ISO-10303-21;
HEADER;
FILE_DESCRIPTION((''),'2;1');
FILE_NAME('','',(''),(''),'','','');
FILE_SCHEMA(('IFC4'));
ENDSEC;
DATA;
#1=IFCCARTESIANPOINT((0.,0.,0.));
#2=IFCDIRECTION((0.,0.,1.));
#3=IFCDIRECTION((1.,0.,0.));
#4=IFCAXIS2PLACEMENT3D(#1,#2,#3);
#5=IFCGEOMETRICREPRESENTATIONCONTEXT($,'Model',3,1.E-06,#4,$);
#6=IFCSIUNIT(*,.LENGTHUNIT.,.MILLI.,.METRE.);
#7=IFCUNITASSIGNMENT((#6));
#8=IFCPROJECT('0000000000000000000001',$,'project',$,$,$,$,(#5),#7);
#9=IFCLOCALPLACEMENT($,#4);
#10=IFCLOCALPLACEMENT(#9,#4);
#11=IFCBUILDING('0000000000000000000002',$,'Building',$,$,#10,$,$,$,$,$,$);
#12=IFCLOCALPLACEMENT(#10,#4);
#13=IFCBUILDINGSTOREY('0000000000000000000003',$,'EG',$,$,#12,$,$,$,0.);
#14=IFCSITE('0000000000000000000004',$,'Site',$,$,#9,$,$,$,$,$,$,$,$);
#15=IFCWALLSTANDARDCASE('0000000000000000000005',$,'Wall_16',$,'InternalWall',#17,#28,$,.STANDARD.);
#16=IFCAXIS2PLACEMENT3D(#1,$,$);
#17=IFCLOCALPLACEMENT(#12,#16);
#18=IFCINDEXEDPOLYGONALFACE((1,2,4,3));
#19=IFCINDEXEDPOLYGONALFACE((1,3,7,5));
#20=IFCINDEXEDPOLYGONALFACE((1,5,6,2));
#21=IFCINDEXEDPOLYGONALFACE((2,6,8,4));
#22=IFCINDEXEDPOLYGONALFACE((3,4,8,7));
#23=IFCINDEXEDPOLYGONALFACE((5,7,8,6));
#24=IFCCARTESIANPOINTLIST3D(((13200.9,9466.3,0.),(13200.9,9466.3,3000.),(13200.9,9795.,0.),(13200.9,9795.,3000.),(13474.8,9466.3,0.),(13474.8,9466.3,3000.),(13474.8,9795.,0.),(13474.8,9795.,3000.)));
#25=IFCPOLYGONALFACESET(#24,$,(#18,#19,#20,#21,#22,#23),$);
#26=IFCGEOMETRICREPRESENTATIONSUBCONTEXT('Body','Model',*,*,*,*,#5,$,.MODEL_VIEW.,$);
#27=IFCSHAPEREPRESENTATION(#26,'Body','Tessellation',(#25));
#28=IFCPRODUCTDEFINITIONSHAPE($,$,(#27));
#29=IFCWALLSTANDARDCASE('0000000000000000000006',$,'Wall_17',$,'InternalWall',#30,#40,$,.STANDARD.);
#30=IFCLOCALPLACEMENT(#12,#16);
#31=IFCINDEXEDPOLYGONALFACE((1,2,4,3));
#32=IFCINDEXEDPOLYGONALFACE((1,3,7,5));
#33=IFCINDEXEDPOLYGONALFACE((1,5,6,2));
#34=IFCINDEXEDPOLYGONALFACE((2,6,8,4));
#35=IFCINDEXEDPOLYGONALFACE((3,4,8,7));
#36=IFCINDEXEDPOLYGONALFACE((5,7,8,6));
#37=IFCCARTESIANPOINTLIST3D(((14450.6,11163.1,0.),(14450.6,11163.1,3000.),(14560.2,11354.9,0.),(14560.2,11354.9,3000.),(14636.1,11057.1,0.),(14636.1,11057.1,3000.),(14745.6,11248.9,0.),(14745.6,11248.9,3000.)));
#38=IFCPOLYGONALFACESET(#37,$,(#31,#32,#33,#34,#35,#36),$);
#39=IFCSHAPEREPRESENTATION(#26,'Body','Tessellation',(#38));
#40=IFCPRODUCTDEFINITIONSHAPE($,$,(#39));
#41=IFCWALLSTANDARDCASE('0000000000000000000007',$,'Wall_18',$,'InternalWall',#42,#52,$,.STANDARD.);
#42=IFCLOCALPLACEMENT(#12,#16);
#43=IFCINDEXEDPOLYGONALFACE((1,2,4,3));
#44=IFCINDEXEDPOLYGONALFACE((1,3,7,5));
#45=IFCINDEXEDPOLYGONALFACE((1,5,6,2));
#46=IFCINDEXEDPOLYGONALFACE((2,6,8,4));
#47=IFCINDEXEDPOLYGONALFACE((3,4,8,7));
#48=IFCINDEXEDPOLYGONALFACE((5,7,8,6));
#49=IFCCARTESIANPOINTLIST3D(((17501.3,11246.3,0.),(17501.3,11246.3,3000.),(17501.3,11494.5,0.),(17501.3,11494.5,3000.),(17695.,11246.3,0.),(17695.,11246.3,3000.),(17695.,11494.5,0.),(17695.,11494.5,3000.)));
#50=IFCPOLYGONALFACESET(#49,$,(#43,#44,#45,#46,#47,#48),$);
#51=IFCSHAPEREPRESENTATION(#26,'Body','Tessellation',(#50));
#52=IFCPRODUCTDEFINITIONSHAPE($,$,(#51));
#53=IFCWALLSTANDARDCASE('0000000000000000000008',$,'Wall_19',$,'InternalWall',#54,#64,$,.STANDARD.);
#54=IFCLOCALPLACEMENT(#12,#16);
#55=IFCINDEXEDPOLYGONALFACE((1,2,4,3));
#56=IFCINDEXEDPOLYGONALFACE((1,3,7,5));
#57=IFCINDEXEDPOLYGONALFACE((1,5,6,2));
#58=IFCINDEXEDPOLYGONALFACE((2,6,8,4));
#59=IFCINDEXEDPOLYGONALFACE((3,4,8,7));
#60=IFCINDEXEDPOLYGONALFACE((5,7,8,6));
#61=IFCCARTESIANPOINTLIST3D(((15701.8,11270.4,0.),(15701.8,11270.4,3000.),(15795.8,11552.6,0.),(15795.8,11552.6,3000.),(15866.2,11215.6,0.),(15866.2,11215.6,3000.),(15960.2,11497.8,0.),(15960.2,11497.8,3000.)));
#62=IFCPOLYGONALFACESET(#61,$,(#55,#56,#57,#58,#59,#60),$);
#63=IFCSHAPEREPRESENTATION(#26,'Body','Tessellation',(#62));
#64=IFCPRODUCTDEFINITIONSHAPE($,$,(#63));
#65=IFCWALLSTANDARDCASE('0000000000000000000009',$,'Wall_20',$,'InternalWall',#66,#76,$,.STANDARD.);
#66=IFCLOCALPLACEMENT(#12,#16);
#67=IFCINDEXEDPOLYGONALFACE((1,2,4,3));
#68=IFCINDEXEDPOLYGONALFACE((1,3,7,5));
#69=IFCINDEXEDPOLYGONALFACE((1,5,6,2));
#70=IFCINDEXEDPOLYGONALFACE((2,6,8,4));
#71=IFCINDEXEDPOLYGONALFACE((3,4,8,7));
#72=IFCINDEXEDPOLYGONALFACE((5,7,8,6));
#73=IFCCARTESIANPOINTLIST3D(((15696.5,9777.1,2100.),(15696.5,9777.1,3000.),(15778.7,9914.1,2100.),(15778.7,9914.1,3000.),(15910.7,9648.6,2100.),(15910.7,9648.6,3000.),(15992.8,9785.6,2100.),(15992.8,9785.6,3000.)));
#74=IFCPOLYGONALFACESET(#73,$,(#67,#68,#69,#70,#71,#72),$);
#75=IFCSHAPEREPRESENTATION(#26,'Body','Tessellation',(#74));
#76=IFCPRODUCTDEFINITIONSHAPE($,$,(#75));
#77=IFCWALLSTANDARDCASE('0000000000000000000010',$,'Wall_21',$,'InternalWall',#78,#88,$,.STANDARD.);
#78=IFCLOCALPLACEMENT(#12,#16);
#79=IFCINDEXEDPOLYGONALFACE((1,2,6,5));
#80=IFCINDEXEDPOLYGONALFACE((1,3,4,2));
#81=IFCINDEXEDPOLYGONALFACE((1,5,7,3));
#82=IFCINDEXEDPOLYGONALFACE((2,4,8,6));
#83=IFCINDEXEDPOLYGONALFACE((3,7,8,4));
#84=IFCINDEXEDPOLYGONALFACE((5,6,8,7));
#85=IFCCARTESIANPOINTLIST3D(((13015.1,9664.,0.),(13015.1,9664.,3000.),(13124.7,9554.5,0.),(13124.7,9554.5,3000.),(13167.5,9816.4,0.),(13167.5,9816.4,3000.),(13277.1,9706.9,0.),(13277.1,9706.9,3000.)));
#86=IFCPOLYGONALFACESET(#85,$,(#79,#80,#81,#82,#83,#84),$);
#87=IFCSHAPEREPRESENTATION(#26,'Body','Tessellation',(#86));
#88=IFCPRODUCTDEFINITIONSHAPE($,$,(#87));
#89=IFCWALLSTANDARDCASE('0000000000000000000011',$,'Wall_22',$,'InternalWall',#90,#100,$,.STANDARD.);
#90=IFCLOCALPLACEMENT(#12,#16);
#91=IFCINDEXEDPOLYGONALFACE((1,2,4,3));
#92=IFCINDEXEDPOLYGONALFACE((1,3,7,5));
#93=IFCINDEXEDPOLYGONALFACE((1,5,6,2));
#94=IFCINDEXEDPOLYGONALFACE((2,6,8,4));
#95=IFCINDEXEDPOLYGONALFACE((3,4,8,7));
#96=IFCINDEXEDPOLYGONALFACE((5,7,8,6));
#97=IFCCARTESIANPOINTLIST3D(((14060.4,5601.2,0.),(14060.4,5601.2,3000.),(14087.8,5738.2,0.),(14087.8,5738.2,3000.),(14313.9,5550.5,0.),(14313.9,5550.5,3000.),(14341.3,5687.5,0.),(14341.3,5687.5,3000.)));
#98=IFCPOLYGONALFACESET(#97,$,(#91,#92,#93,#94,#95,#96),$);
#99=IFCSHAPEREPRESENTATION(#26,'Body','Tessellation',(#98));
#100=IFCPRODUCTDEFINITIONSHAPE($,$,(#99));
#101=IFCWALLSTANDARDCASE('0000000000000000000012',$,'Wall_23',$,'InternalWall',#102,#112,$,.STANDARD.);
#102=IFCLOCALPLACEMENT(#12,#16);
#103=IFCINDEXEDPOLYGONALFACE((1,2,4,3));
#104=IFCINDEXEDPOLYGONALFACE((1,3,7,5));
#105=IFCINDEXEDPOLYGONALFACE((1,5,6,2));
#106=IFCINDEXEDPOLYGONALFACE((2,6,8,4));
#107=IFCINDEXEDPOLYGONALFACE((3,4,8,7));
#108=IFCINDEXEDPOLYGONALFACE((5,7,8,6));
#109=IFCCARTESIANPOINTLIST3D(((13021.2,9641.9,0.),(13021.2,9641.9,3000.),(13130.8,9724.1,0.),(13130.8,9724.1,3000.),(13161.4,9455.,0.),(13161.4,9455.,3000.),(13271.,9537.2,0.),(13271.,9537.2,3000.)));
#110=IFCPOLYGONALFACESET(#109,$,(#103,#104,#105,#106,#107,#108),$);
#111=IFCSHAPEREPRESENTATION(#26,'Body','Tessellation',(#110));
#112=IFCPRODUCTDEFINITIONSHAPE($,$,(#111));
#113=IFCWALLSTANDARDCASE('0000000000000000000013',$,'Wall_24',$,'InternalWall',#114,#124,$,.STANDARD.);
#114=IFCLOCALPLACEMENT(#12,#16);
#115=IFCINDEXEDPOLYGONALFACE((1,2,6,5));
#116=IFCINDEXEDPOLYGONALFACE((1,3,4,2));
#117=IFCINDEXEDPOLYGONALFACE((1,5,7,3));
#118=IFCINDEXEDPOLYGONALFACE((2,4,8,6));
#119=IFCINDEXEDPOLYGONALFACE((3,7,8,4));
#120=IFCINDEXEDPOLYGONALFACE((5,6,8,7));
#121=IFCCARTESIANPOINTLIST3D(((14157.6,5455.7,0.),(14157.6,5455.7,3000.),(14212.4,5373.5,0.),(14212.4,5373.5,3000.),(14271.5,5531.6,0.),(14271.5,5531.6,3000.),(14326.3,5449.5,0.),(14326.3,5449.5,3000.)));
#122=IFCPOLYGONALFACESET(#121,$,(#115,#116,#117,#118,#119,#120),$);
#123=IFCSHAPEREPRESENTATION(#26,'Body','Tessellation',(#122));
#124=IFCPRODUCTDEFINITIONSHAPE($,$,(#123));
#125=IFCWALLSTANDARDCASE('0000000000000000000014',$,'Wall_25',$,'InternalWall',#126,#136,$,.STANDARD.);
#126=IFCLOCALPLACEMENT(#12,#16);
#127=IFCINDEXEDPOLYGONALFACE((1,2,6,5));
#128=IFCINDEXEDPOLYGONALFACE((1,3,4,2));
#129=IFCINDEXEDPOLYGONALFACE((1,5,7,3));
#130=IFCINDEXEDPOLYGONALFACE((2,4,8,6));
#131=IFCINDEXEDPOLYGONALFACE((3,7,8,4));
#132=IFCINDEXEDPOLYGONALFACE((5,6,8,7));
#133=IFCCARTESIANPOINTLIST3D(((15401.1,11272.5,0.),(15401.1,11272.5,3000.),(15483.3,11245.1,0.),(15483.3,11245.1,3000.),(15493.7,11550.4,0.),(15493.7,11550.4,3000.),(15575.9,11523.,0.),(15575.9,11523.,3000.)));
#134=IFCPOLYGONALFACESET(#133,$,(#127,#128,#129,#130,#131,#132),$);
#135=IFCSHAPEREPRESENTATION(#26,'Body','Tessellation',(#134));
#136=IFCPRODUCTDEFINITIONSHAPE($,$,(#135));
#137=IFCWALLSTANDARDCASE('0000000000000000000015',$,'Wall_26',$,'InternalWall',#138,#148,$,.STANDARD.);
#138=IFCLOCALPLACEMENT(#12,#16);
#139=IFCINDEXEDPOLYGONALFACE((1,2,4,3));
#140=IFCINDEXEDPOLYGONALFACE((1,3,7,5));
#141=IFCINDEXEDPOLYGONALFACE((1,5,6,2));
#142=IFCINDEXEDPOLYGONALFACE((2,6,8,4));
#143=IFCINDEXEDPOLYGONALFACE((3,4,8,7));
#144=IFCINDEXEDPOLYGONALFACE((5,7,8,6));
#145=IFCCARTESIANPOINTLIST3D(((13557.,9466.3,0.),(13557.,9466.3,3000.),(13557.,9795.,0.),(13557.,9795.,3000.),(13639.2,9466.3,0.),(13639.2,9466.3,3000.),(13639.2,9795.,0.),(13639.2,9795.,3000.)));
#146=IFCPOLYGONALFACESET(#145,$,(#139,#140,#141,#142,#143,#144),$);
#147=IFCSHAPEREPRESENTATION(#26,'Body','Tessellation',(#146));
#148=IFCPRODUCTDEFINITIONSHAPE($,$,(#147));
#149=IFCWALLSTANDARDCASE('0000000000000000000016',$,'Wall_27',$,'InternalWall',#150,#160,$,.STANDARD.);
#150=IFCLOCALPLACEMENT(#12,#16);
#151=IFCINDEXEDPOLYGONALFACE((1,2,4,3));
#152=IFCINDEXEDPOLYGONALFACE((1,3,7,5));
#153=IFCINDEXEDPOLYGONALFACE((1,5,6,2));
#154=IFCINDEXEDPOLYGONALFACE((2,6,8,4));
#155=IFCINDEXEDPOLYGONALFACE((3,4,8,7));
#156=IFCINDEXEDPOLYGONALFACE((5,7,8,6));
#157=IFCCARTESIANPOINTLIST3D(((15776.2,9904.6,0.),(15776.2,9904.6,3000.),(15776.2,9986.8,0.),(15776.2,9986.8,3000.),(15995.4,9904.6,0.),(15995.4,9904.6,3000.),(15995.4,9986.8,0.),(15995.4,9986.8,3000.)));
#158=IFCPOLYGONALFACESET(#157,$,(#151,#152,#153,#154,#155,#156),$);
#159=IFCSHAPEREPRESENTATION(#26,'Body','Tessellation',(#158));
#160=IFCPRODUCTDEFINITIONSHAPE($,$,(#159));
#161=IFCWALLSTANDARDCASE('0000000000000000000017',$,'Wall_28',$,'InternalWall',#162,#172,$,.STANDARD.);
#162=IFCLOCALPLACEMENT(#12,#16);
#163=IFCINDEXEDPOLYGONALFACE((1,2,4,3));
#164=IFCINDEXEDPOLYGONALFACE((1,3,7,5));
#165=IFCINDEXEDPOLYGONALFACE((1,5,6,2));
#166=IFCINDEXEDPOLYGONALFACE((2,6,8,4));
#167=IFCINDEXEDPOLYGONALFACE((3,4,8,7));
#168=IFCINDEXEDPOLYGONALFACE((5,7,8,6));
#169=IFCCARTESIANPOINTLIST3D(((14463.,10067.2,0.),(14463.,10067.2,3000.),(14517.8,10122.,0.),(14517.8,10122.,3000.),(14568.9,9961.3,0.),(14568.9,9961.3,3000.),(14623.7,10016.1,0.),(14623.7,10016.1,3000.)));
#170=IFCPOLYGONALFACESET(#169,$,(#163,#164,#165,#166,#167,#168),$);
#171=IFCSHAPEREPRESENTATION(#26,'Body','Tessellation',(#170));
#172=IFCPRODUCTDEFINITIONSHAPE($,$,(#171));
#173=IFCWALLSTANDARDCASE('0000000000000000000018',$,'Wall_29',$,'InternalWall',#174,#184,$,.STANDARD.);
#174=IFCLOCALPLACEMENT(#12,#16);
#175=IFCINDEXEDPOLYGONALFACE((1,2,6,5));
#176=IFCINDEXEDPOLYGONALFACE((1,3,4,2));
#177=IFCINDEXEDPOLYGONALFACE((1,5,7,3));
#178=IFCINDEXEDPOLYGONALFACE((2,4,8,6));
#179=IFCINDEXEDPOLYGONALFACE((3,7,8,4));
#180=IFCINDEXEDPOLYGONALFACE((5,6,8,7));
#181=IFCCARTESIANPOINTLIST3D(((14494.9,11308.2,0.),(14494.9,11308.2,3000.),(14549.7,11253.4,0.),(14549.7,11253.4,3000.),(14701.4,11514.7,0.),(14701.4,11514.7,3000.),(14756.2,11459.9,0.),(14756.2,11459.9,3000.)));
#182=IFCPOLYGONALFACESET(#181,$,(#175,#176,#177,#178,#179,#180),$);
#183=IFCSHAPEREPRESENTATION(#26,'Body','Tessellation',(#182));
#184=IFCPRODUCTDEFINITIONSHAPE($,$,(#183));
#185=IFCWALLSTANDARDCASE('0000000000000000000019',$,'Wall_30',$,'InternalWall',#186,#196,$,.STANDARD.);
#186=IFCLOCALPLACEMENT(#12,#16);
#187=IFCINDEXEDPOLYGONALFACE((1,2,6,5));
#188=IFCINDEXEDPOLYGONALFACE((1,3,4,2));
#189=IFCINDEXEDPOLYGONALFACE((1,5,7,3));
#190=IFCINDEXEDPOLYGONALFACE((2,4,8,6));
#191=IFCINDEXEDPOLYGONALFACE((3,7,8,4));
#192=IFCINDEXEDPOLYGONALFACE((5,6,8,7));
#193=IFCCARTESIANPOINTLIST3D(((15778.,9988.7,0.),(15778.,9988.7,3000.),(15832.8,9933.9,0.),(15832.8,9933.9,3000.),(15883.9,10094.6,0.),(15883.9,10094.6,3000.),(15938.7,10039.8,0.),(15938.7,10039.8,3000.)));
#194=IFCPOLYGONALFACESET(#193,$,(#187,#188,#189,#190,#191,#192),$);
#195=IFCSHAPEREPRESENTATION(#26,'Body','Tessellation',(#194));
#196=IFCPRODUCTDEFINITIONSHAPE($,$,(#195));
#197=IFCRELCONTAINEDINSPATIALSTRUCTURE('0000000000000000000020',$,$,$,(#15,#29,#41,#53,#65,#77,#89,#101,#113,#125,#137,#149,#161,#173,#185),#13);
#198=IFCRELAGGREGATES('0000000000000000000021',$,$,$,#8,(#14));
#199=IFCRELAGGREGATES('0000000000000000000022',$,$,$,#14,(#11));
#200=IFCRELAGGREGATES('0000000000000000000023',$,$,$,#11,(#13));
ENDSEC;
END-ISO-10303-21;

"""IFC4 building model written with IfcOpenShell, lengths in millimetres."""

from ifc_helpers import new_model, si_unit, frame, origin_with_axes, place, context, subcontext, project, spatial, rectangle, extrude, element, save


model = new_model("IFC4")

# Units and contexts
model_context = context("Model", 3, precision=1e-06, world=origin_with_axes())
body_context = subcontext(model_context, "Body", "Model", "MODEL_VIEW")
ifc_project = project(units=[si_unit("LENGTHUNIT", "METRE", prefix="MILLI")], contexts=[model_context])

# Site, building, storey
site_placement = place(None, origin_with_axes())
site = spatial("IfcSite", under=ifc_project, at=site_placement, Name="Site")
building_placement = place(site_placement, origin_with_axes())
building = spatial("IfcBuilding", under=site, at=building_placement, Name="Building")
storey_placement = place(building_placement, origin_with_axes())
storey = spatial("IfcBuildingStorey", under=building, at=storey_placement, Name="EG", Elevation=0.0)

# Walls
wall_1_placement = place(storey_placement, origin_with_axes())
element("IfcWallStandardCase", 1, at=wall_1_placement, inside=storey, Name="Wall_16", ObjectType="InternalWall", PredefinedType="STANDARD", context=body_context, shape_type="SweptSolid", body=[
    extrude(rectangle(XDim=274.0, YDim=328.8), frame((13337.8, 9630.7, 0.0), z_axis=(0.0, 0.0, 1.0), x_axis=(-1.0, 0.0, 0.0)), (0.0, 0.0, 1.0), 3000.0),
])
wall_2_placement = place(storey_placement, origin_with_axes())
element("IfcWallStandardCase", 2, at=wall_2_placement, inside=storey, Name="Wall_17", ObjectType="InternalWall", PredefinedType="STANDARD", context=body_context, shape_type="SweptSolid", body=[
    extrude(rectangle(XDim=220.9, YDim=213.6), frame((14598.1, 11206.0, 0.0), z_axis=(0.0, 0.0, 1.0), x_axis=(-0.496139, -0.868243, 0.0)), (0.0, 0.0, 1.0), 3000.0),
])
wall_3_placement = place(storey_placement, origin_with_axes())
element("IfcWallStandardCase", 3, at=wall_3_placement, inside=storey, Name="Wall_18", ObjectType="InternalWall", PredefinedType="STANDARD", context=body_context, shape_type="SweptSolid", body=[
    extrude(rectangle(XDim=193.7, YDim=248.2), frame((17598.1, 11370.4, 0.0), z_axis=(0.0, 0.0, 1.0), x_axis=(1.0, 0.0, 0.0)), (0.0, 0.0, 1.0), 3000.0),
])
wall_4_placement = place(storey_placement, origin_with_axes())
element("IfcWallStandardCase", 4, at=wall_4_placement, inside=storey, Name="Wall_19", ObjectType="InternalWall", PredefinedType="STANDARD", context=body_context, shape_type="SweptSolid", body=[
    extrude(rectangle(XDim=173.3, YDim=297.5), frame((15831.0, 11384.1, 0.0), z_axis=(0.0, 0.0, 1.0), x_axis=(0.948683, -0.316228, 0.0)), (0.0, 0.0, 1.0), 3000.0),
])

# Wall, opening
wall_5_placement = place(storey_placement, origin_with_axes())
wall_5 = element("IfcWallStandardCase", 5, at=wall_5_placement, inside=storey, Name="Wall_20", ObjectType="InternalWall", PredefinedType="STANDARD", context=body_context, shape_type="SweptSolid", body=[
    extrude(rectangle(XDim=159.8, YDim=249.7), frame((15844.7, 9781.3, 0.0), z_axis=(0.0, 0.0, 1.0), x_axis=(0.514496, 0.857493, 0.0)), (0.0, 0.0, 1.0), 3000.0),
])
opening_1_placement = place(wall_5_placement, origin_with_axes())
element("IfcOpeningElement", 6, at=opening_1_placement, inside=storey, cuts=wall_5, context=body_context, shape_type="SweptSolid", body=[
    extrude(rectangle(XDim=450.0, YDim=249.7), frame((15844.7, 9781.3, 0.0), z_axis=(0.0, 0.0, 1.0), x_axis=(0.514496, 0.857493, 0.0)), (0.0, 0.0, 1.0), 2100.0),
])

# Walls
wall_6_placement = place(storey_placement, origin_with_axes())
element("IfcWallStandardCase", 7, at=wall_6_placement, inside=storey, Name="Wall_21", ObjectType="InternalWall", PredefinedType="STANDARD", context=body_context, shape_type="SweptSolid", body=[
    extrude(rectangle(XDim=155.0, YDim=215.5), frame((13146.1, 9685.4, 0.0), z_axis=(0.0, 0.0, 1.0), x_axis=(-0.707107, 0.707107, 0.0)), (0.0, 0.0, 1.0), 3000.0),
])
wall_7_placement = place(storey_placement, origin_with_axes())
element("IfcWallStandardCase", 8, at=wall_7_placement, inside=storey, Name="Wall_22", ObjectType="InternalWall", PredefinedType="STANDARD", context=body_context, shape_type="SweptSolid", body=[
    extrude(rectangle(XDim=139.7, YDim=258.5), frame((14200.9, 5644.3, 0.0), z_axis=(0.0, 0.0, 1.0), x_axis=(-0.196116, -0.980581, 0.0)), (0.0, 0.0, 1.0), 3000.0),
])
wall_8_placement = place(storey_placement, origin_with_axes())
element("IfcWallStandardCase", 9, at=wall_8_placement, inside=storey, Name="Wall_23", ObjectType="InternalWall", PredefinedType="STANDARD", context=body_context, shape_type="SweptSolid", body=[
    extrude(rectangle(XDim=137.0, YDim=233.7), frame((13146.1, 9589.6, 0.0), z_axis=(0.0, 0.0, 1.0), x_axis=(-0.8, -0.6, 0.0)), (0.0, 0.0, 1.0), 3000.0),
])
wall_9_placement = place(storey_placement, origin_with_axes())
element("IfcWallStandardCase", 10, at=wall_9_placement, inside=storey, Name="Wall_24", ObjectType="InternalWall", PredefinedType="STANDARD", context=body_context, shape_type="SweptSolid", body=[
    extrude(rectangle(XDim=98.8, YDim=136.9), frame((14242.0, 5452.6, 0.0), z_axis=(0.0, 0.0, 1.0), x_axis=(0.5547, -0.83205, 0.0)), (0.0, 0.0, 1.0), 3000.0),
])
wall_10_placement = place(storey_placement, origin_with_axes())
element("IfcWallStandardCase", 11, at=wall_10_placement, inside=storey, Name="Wall_25", ObjectType="InternalWall", PredefinedType="STANDARD", context=body_context, shape_type="SweptSolid", body=[
    extrude(rectangle(XDim=86.6, YDim=292.9), frame((15488.5, 11397.8, 0.0), z_axis=(0.0, 0.0, 1.0), x_axis=(0.948683, -0.316228, 0.0)), (0.0, 0.0, 1.0), 3000.0),
])
wall_11_placement = place(storey_placement, origin_with_axes())
element("IfcWallStandardCase", 12, at=wall_11_placement, inside=storey, Name="Wall_26", ObjectType="InternalWall", PredefinedType="STANDARD", context=body_context, shape_type="SweptSolid", body=[
    extrude(rectangle(XDim=82.2, YDim=328.8), frame((13598.1, 9630.7, 0.0), z_axis=(0.0, 0.0, 1.0), x_axis=(-1.0, 0.0, 0.0)), (0.0, 0.0, 1.0), 3000.0),
])
wall_12_placement = place(storey_placement, origin_with_axes())
element("IfcWallStandardCase", 13, at=wall_12_placement, inside=storey, Name="Wall_27", ObjectType="InternalWall", PredefinedType="STANDARD", context=body_context, shape_type="SweptSolid", body=[
    extrude(rectangle(XDim=82.2, YDim=219.2), frame((15885.8, 9945.7, 0.0), z_axis=(0.0, 0.0, 1.0), x_axis=(0.0, 1.0, 0.0)), (0.0, 0.0, 1.0), 3000.0),
])
wall_13_placement = place(storey_placement, origin_with_axes())
element("IfcWallStandardCase", 14, at=wall_13_placement, inside=storey, Name="Wall_28", ObjectType="InternalWall", PredefinedType="STANDARD", context=body_context, shape_type="SweptSolid", body=[
    extrude(rectangle(XDim=77.5, YDim=149.8), frame((14543.3, 10041.6, 0.0), z_axis=(0.0, 0.0, 1.0), x_axis=(0.707107, 0.707107, 0.0)), (0.0, 0.0, 1.0), 3000.0),
])
wall_14_placement = place(storey_placement, origin_with_axes())
element("IfcWallStandardCase", 15, at=wall_14_placement, inside=storey, Name="Wall_29", ObjectType="InternalWall", PredefinedType="STANDARD", context=body_context, shape_type="SweptSolid", body=[
    extrude(rectangle(XDim=77.5, YDim=292.0), frame((14625.5, 11384.1, 0.0), z_axis=(0.0, 0.0, 1.0), x_axis=(-0.707107, 0.707107, 0.0)), (0.0, 0.0, 1.0), 3000.0),
])
wall_15_placement = place(storey_placement, origin_with_axes())
element("IfcWallStandardCase", 16, at=wall_15_placement, inside=storey, Name="Wall_30", ObjectType="InternalWall", PredefinedType="STANDARD", context=body_context, shape_type="SweptSolid", body=[
    extrude(rectangle(XDim=77.5, YDim=149.8), frame((15858.4, 10014.2, 0.0), z_axis=(0.0, 0.0, 1.0), x_axis=(-0.707107, 0.707107, 0.0)), (0.0, 0.0, 1.0), 3000.0),
])

save(model, "model.ifc")
